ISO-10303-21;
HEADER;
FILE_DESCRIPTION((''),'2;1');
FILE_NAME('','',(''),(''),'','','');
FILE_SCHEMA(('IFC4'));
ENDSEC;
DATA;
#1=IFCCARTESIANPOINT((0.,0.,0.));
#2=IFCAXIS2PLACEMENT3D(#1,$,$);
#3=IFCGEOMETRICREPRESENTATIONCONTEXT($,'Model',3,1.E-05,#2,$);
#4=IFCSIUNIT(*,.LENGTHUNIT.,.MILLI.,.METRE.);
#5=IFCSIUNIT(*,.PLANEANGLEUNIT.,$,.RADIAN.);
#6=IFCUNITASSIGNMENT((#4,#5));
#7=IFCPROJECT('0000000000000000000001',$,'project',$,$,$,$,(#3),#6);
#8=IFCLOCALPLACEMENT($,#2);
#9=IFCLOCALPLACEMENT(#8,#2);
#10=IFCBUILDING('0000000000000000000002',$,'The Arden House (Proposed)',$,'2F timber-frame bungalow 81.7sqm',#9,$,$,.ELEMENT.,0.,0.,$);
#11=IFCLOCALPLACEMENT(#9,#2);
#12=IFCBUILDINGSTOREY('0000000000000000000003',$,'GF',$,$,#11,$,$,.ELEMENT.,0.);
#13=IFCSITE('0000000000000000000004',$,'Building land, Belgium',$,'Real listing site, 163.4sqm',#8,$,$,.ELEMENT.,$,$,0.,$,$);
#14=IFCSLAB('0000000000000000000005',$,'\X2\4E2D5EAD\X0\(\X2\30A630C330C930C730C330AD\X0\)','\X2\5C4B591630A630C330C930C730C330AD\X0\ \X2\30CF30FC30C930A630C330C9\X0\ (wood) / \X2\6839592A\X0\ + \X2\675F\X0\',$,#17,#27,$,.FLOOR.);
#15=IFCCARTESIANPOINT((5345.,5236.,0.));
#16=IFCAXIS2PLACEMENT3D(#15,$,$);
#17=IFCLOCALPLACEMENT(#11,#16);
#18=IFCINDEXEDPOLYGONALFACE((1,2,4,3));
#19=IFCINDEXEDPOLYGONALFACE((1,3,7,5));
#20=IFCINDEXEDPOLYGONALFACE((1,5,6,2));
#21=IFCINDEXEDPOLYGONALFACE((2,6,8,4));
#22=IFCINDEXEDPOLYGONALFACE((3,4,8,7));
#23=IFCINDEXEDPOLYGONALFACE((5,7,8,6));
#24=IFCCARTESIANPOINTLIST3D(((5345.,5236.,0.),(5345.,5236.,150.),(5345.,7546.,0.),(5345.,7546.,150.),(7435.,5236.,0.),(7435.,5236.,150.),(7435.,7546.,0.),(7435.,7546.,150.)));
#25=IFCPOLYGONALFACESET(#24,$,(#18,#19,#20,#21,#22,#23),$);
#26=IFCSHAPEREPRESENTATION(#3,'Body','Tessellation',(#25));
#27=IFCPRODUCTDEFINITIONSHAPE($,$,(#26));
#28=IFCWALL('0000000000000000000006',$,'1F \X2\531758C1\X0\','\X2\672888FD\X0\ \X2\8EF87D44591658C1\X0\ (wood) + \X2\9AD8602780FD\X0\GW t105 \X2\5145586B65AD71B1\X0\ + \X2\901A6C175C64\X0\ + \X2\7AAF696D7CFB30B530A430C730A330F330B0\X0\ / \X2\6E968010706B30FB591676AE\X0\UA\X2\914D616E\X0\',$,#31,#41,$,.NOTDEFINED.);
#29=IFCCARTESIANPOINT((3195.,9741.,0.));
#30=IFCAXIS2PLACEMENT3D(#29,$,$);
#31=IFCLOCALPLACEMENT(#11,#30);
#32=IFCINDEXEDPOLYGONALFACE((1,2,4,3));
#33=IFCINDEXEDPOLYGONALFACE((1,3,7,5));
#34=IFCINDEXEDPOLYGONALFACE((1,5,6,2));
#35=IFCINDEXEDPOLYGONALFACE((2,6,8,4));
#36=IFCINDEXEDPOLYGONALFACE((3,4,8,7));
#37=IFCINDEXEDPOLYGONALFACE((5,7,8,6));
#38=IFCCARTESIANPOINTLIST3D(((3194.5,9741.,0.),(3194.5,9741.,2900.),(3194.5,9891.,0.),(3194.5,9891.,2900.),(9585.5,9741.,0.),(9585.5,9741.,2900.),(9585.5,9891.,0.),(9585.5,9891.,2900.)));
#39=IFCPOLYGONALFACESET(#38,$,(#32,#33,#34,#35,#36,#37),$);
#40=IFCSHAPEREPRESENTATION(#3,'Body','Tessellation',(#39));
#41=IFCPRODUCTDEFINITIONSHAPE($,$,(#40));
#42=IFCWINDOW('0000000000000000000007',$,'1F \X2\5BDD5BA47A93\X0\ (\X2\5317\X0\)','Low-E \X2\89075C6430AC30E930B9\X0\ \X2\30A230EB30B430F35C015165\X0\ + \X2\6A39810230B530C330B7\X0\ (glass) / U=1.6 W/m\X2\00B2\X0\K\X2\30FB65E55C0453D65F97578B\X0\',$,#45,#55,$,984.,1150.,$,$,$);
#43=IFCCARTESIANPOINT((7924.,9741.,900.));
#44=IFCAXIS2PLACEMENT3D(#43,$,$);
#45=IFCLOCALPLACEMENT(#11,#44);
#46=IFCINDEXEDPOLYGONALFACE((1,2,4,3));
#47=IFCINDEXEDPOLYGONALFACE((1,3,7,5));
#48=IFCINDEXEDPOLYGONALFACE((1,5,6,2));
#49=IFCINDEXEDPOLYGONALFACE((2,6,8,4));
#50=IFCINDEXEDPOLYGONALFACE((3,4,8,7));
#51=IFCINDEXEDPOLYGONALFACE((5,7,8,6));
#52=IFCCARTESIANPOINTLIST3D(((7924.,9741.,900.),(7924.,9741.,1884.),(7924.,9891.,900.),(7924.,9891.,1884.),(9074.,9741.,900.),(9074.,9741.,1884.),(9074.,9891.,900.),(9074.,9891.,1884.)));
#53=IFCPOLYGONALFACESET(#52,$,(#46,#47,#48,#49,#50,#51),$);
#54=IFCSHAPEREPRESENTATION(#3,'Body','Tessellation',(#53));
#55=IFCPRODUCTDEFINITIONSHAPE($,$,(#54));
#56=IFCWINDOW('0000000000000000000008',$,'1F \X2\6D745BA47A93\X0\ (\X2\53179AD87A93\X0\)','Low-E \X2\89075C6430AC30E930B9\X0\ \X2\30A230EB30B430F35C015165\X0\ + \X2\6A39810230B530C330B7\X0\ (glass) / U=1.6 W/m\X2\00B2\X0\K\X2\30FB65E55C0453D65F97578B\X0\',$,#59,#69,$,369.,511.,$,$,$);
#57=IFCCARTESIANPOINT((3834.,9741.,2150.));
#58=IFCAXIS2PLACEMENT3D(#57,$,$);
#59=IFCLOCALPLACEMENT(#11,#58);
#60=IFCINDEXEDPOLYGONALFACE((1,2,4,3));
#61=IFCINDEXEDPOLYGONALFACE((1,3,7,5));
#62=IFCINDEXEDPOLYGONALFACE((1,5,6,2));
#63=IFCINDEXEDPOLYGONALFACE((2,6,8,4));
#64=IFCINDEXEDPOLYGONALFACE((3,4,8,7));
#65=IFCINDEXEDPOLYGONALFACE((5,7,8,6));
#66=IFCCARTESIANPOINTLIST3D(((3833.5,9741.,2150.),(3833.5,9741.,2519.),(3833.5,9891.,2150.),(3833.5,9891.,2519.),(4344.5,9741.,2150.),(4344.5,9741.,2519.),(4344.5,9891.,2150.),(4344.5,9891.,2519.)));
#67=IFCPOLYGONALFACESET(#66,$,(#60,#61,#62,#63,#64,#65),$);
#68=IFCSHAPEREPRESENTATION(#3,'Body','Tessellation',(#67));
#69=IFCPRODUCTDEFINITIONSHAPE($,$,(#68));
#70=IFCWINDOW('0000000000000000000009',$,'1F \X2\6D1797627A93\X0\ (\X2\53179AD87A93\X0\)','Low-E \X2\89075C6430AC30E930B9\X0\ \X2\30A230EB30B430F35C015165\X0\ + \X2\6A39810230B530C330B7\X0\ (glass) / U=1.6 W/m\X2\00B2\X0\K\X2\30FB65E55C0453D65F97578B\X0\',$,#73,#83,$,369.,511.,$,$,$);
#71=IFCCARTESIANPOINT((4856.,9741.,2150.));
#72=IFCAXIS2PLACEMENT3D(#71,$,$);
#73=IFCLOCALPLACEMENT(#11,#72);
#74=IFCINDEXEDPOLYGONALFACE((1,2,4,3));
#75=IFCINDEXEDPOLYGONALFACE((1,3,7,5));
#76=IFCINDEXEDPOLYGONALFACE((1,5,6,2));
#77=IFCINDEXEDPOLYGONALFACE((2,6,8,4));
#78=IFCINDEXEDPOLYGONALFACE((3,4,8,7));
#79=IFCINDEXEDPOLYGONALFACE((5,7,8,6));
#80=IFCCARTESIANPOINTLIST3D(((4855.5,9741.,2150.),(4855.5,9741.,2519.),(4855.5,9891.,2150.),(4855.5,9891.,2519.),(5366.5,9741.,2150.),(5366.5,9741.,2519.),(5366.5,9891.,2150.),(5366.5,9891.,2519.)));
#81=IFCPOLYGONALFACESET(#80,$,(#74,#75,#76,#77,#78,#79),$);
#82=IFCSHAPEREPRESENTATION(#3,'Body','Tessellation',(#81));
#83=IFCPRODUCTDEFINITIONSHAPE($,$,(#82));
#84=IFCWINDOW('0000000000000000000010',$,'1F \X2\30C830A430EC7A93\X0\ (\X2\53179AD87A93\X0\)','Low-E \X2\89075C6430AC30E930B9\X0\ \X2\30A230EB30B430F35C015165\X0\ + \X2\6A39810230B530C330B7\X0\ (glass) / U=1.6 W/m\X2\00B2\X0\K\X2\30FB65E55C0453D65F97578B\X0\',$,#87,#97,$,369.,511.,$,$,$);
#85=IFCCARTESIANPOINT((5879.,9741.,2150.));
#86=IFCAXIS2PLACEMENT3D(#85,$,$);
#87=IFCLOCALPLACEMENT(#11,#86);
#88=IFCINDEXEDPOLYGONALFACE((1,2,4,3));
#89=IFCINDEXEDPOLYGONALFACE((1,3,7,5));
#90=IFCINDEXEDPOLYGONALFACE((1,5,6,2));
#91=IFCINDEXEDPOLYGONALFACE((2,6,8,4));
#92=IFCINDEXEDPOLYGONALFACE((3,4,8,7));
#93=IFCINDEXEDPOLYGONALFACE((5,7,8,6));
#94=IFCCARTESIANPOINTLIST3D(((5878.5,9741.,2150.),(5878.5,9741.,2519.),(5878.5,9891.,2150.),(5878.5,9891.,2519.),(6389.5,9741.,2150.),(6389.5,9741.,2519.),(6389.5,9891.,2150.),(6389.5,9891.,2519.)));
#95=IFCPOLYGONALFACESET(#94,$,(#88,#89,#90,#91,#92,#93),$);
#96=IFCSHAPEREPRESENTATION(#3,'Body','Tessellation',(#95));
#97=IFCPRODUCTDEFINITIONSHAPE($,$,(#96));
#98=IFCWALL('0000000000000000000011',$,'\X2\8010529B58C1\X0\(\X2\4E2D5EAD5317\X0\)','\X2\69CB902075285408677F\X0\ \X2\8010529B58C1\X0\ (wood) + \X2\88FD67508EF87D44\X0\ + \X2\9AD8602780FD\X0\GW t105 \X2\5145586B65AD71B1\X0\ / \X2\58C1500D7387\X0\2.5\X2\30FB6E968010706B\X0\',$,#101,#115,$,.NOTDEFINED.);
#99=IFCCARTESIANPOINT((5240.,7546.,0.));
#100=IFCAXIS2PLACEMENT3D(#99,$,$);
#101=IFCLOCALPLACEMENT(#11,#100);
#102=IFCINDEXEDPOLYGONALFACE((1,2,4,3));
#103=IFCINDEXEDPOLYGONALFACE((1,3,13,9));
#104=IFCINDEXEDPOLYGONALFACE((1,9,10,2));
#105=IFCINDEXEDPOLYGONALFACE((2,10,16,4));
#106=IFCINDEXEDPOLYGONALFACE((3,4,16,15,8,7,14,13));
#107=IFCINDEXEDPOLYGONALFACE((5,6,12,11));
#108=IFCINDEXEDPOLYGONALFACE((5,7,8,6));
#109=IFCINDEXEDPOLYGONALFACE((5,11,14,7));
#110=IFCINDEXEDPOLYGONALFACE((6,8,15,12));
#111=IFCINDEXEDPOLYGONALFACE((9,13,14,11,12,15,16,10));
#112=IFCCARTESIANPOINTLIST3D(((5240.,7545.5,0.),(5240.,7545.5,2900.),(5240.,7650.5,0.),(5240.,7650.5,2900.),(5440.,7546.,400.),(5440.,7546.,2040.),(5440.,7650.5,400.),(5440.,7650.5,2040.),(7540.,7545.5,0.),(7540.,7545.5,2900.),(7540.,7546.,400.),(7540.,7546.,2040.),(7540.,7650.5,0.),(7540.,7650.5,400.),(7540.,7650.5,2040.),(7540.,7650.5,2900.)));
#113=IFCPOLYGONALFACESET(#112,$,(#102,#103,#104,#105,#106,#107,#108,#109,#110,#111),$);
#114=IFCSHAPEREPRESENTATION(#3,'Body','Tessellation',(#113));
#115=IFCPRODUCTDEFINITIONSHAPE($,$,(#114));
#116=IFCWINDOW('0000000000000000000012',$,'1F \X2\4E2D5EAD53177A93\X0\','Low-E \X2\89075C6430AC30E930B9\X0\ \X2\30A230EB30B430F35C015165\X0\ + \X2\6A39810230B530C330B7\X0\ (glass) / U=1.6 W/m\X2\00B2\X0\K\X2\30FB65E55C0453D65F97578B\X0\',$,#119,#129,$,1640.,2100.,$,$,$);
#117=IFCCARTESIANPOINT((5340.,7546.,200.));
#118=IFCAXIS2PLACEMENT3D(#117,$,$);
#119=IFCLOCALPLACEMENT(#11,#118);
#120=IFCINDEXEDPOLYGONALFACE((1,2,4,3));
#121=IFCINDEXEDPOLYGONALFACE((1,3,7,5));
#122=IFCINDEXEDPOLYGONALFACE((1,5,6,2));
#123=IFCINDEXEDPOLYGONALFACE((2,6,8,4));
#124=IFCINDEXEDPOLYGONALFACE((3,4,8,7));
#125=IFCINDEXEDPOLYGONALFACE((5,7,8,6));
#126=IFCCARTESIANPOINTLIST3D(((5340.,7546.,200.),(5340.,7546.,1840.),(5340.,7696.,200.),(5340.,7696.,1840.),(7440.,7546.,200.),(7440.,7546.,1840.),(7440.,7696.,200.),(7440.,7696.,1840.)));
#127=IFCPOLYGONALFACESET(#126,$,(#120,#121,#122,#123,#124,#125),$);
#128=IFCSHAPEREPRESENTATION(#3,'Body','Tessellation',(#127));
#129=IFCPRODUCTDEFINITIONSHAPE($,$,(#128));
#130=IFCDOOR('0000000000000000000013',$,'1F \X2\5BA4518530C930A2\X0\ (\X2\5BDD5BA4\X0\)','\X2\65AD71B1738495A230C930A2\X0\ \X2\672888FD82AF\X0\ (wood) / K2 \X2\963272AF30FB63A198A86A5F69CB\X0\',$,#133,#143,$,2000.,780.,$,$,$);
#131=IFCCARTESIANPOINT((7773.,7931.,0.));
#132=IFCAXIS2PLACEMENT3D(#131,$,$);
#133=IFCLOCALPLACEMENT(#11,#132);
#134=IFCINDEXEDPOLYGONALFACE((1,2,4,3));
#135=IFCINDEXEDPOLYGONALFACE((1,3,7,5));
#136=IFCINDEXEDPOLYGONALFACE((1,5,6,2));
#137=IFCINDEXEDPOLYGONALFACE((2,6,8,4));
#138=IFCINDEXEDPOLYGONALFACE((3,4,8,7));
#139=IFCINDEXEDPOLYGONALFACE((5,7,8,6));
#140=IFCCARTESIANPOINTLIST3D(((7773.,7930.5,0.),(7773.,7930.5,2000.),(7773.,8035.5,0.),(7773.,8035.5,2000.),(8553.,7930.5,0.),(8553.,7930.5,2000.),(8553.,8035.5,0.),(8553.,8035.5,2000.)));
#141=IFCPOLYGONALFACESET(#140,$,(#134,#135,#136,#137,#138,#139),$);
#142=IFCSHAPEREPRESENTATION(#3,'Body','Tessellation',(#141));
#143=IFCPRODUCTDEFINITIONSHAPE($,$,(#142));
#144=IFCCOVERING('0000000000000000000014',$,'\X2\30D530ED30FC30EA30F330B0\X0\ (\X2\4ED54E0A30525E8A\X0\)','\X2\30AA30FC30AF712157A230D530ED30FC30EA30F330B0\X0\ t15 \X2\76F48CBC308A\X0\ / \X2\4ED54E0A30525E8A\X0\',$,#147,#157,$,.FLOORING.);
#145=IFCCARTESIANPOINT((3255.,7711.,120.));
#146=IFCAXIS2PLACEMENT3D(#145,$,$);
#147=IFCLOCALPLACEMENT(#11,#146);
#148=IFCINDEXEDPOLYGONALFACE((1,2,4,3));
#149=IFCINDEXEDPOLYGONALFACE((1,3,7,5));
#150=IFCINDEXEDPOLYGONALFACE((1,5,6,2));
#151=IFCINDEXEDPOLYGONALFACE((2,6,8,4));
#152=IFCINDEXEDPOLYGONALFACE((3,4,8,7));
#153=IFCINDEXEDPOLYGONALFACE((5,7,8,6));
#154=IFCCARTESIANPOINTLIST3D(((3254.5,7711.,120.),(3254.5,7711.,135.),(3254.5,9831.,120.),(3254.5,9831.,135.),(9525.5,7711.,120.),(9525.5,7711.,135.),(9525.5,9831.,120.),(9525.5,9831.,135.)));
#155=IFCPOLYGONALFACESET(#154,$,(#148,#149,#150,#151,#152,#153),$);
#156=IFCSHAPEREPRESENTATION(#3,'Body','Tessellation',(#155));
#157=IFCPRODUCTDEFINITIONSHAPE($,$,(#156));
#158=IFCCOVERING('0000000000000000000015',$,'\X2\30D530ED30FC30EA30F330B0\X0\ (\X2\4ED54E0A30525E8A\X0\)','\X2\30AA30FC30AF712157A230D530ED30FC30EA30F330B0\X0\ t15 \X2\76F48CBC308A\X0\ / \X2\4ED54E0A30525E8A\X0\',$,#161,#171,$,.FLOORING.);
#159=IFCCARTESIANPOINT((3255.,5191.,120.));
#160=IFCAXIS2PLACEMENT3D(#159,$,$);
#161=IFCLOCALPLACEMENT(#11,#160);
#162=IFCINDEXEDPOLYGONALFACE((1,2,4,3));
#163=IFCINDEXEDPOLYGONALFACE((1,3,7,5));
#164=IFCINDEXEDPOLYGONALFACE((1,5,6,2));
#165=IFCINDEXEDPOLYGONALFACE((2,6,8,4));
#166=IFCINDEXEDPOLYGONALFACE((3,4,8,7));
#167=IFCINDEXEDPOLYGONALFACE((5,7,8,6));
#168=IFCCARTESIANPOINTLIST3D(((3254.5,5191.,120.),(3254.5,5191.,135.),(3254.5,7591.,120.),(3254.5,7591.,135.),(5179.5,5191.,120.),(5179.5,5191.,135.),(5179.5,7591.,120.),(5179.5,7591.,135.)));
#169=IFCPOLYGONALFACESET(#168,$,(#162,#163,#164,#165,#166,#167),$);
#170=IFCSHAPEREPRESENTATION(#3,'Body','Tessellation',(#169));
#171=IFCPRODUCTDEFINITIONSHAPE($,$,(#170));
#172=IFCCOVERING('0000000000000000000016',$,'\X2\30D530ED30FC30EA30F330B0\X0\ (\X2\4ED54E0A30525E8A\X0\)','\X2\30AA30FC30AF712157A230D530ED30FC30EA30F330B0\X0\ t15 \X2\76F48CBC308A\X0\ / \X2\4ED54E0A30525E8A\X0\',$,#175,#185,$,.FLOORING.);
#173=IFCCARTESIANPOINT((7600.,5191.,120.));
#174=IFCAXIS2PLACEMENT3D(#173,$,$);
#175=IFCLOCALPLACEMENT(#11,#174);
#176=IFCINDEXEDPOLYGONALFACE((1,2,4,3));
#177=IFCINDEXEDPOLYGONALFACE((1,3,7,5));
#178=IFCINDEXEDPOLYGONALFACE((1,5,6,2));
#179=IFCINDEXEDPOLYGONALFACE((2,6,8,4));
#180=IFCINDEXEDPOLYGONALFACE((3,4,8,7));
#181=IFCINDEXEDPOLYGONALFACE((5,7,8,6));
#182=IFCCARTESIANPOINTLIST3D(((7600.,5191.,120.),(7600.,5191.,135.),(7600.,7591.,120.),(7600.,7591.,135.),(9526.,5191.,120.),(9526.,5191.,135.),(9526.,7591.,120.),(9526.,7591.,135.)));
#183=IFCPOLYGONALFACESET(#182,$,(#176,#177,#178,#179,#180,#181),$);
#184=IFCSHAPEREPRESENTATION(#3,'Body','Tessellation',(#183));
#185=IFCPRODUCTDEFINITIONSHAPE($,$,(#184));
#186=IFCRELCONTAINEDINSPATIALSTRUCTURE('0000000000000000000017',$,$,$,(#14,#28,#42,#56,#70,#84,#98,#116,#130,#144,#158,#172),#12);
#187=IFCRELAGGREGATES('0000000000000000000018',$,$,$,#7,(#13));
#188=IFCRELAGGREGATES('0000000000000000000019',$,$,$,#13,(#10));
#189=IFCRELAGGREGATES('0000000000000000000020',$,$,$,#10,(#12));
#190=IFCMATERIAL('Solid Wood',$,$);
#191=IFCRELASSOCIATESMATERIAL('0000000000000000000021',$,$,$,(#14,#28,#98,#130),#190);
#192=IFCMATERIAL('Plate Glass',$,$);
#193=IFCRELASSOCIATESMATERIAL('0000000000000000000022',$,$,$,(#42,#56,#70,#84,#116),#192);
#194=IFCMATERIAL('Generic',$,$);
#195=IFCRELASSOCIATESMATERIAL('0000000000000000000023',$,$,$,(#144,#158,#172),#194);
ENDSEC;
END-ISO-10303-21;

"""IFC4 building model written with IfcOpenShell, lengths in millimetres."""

from ifc_helpers import new_model, si_unit, frame, frame_2d, origin, place, context, project, spatial, rectangle, extrude, material, element, fill, save


model = new_model("IFC4")

# Units and contexts
model_context = context("Model", 3, precision=1e-05, world=origin())
ifc_project = project(units=[si_unit("LENGTHUNIT", "METRE", prefix="MILLI"), si_unit("PLANEANGLEUNIT", "RADIAN")], contexts=[model_context])

# Site, building, storey
site_placement = place(None, origin())
site = spatial("IfcSite", under=ifc_project, at=site_placement, Name="Building land, Belgium", ObjectType="Real listing site, 163.4sqm", CompositionType="ELEMENT", RefElevation=0.0)
building_placement = place(site_placement, origin())
building = spatial("IfcBuilding", under=site, at=building_placement, Name="The Arden House (Proposed)", ObjectType="2F timber-frame bungalow 81.7sqm", CompositionType="ELEMENT", ElevationOfRefHeight=0.0, ElevationOfTerrain=0.0)
storey_placement = place(building_placement, origin())
storey = spatial("IfcBuildingStorey", under=building, at=storey_placement, Name="GF", CompositionType="ELEMENT", Elevation=0.0)

# Slab
ifc_material_1 = material(Name="Solid Wood")
slab_1_placement = place(storey_placement, frame((5345.0, 5236.0, 0.0)))
element("IfcSlab", 1, at=slab_1_placement, inside=storey, material=ifc_material_1, Name="中庭(ウッドデッキ)", Description="屋外ウッドデッキ ハードウッド (wood) / 根太 + 束", PredefinedType="FLOOR", context=model_context, shape_type="SweptSolid", body=[
    extrude(rectangle(XDim=2090.0, YDim=2310.0, at=frame_2d((1045.0, 1155.0))), frame((5345.0, 5236.0, 0.0)), (0.0, 0.0, 1.0), 150.0),
])

# Wall, openings, windows
wall_1_placement = place(storey_placement, frame((3195.0, 9741.0, 0.0)))
wall_1 = element("IfcWall", 2, at=wall_1_placement, inside=storey, material=ifc_material_1, Name="1F 北壁", Description="木製 軸組外壁 (wood) + 高性能GW t105 充填断熱 + 通気層 + 窯業系サイディング / 準耐火・外皮UA配慮", PredefinedType="NOTDEFINED", context=model_context, shape_type="SweptSolid", body=[
    extrude(rectangle(XDim=6391.0, YDim=150.0, at=frame_2d((3195.0, 75.0))), frame((3195.0, 9741.0, 0.0)), (0.0, 0.0, 1.0), 2900.0),
])
opening_1_placement = place(storey_placement, frame((7924.0, 9741.0, 900.0)))
opening_1 = element("IfcOpeningElement", 3, at=opening_1_placement, cuts=wall_1, PredefinedType="NOTDEFINED", context=model_context, shape_type="SweptSolid", body=[
    extrude(rectangle(XDim=1150.0, YDim=150.0, at=frame_2d((575.0, 75.0))), frame((7924.0, 9741.0, 900.0)), (0.0, 0.0, 1.0), 984.0),
])
opening_2_placement = place(storey_placement, frame((3834.0, 9741.0, 2150.0)))
opening_2 = element("IfcOpeningElement", 4, at=opening_2_placement, cuts=wall_1, PredefinedType="NOTDEFINED", context=model_context, shape_type="SweptSolid", body=[
    extrude(rectangle(XDim=511.0, YDim=150.0, at=frame_2d((255.0, 75.0))), frame((3834.0, 9741.0, 2150.0)), (0.0, 0.0, 1.0), 369.0),
])
opening_3_placement = place(storey_placement, frame((4856.0, 9741.0, 2150.0)))
opening_3 = element("IfcOpeningElement", 5, at=opening_3_placement, cuts=wall_1, PredefinedType="NOTDEFINED", context=model_context, shape_type="SweptSolid", body=[
    extrude(rectangle(XDim=511.0, YDim=150.0, at=frame_2d((255.0, 75.0))), frame((4856.0, 9741.0, 2150.0)), (0.0, 0.0, 1.0), 369.0),
])
opening_4_placement = place(storey_placement, frame((5879.0, 9741.0, 2150.0)))
opening_4 = element("IfcOpeningElement", 6, at=opening_4_placement, cuts=wall_1, PredefinedType="NOTDEFINED", context=model_context, shape_type="SweptSolid", body=[
    extrude(rectangle(XDim=511.0, YDim=150.0, at=frame_2d((255.0, 75.0))), frame((5879.0, 9741.0, 2150.0)), (0.0, 0.0, 1.0), 369.0),
])
ifc_material_2 = material(Name="Plate Glass")
window_1_placement = place(storey_placement, frame((7924.0, 9741.0, 900.0)))
window_1 = element("IfcWindow", 7, at=window_1_placement, inside=storey, material=ifc_material_2, Name="1F 寝室窓 (北)", Description="Low-E 複層ガラス アルゴン封入 + 樹脂サッシ (glass) / U=1.6 W/m²K・日射取得型", OverallHeight=984.0, OverallWidth=1150.0, context=model_context, shape_type="SweptSolid", body=[
    extrude(rectangle(XDim=1150.0, YDim=150.0, at=frame_2d((575.0, 75.0))), frame((7924.0, 9741.0, 900.0)), (0.0, 0.0, 1.0), 984.0),
])
fill(opening_1, window_1)
window_2_placement = place(storey_placement, frame((3834.0, 9741.0, 2150.0)))
window_2 = element("IfcWindow", 8, at=window_2_placement, inside=storey, material=ifc_material_2, Name="1F 浴室窓 (北高窓)", Description="Low-E 複層ガラス アルゴン封入 + 樹脂サッシ (glass) / U=1.6 W/m²K・日射取得型", OverallHeight=369.0, OverallWidth=511.0, context=model_context, shape_type="SweptSolid", body=[
    extrude(rectangle(XDim=511.0, YDim=150.0, at=frame_2d((255.0, 75.0))), frame((3834.0, 9741.0, 2150.0)), (0.0, 0.0, 1.0), 369.0),
])
fill(opening_2, window_2)
window_3_placement = place(storey_placement, frame((4856.0, 9741.0, 2150.0)))
window_3 = element("IfcWindow", 9, at=window_3_placement, inside=storey, material=ifc_material_2, Name="1F 洗面窓 (北高窓)", Description="Low-E 複層ガラス アルゴン封入 + 樹脂サッシ (glass) / U=1.6 W/m²K・日射取得型", OverallHeight=369.0, OverallWidth=511.0, context=model_context, shape_type="SweptSolid", body=[
    extrude(rectangle(XDim=511.0, YDim=150.0, at=frame_2d((255.0, 75.0))), frame((4856.0, 9741.0, 2150.0)), (0.0, 0.0, 1.0), 369.0),
])
fill(opening_3, window_3)
window_4_placement = place(storey_placement, frame((5879.0, 9741.0, 2150.0)))
window_4 = element("IfcWindow", 10, at=window_4_placement, inside=storey, material=ifc_material_2, Name="1F トイレ窓 (北高窓)", Description="Low-E 複層ガラス アルゴン封入 + 樹脂サッシ (glass) / U=1.6 W/m²K・日射取得型", OverallHeight=369.0, OverallWidth=511.0, context=model_context, shape_type="SweptSolid", body=[
    extrude(rectangle(XDim=511.0, YDim=150.0, at=frame_2d((255.0, 75.0))), frame((5879.0, 9741.0, 2150.0)), (0.0, 0.0, 1.0), 369.0),
])
fill(opening_4, window_4)

# Wall, opening, window
wall_2_placement = place(storey_placement, frame((5240.0, 7546.0, 0.0)))
wall_2 = element("IfcWall", 11, at=wall_2_placement, inside=storey, material=ifc_material_1, Name="耐力壁(中庭北)", Description="構造用合板 耐力壁 (wood) + 製材軸組 + 高性能GW t105 充填断熱 / 壁倍率2.5・準耐火", PredefinedType="NOTDEFINED", context=model_context, shape_type="SweptSolid", body=[
    extrude(rectangle(XDim=2300.0, YDim=105.0, at=frame_2d((1150.0, 52.0))), frame((5240.0, 7546.0, 0.0)), (0.0, 0.0, 1.0), 2900.0),
])
opening_5_placement = place(storey_placement, frame((5340.0, 7546.0, 200.0)))
opening_5 = element("IfcOpeningElement", 12, at=opening_5_placement, cuts=wall_2, PredefinedType="NOTDEFINED", context=model_context, shape_type="SweptSolid", body=[
    extrude(rectangle(XDim=2100.0, YDim=150.0, at=frame_2d((1050.0, 75.0))), frame((5340.0, 7546.0, 200.0)), (0.0, 0.0, 1.0), 1640.0),
])
window_5_placement = place(storey_placement, frame((5340.0, 7546.0, 200.0)))
window_5 = element("IfcWindow", 13, at=window_5_placement, inside=storey, material=ifc_material_2, Name="1F 中庭北窓", Description="Low-E 複層ガラス アルゴン封入 + 樹脂サッシ (glass) / U=1.6 W/m²K・日射取得型", OverallHeight=1640.0, OverallWidth=2100.0, context=model_context, shape_type="SweptSolid", body=[
    extrude(rectangle(XDim=2100.0, YDim=150.0, at=frame_2d((1050.0, 75.0))), frame((5340.0, 7546.0, 200.0)), (0.0, 0.0, 1.0), 1640.0),
])
fill(opening_5, window_5)

# Door
door_1_placement = place(storey_placement, frame((7773.0, 7931.0, 0.0)))
element("IfcDoor", 14, at=door_1_placement, inside=storey, material=ifc_material_1, Name="1F 室内ドア (寝室)", Description="断熱玄関ドア 木製芯 (wood) / K2 防犯・採風機構", OverallHeight=2000.0, OverallWidth=780.0, context=model_context, shape_type="SweptSolid", body=[
    extrude(rectangle(XDim=780.0, YDim=105.0, at=frame_2d((390.0, 52.0))), frame((7773.0, 7931.0, 0.0)), (0.0, 0.0, 1.0), 2000.0),
])

# Coverings
ifc_material_3 = material(Name="Generic")
covering_1_placement = place(storey_placement, frame((3255.0, 7711.0, 120.0)))
element("IfcCovering", 15, at=covering_1_placement, inside=storey, material=ifc_material_3, Name="フローリング (仕上げ床)", Description="オーク無垢フローリング t15 直貼り / 仕上げ床", PredefinedType="FLOORING", context=model_context, shape_type="SweptSolid", body=[
    extrude(rectangle(XDim=6271.0, YDim=2120.0, at=frame_2d((3135.0, 1060.0))), frame((3255.0, 7711.0, 120.0)), (0.0, 0.0, 1.0), 15.0),
])
covering_2_placement = place(storey_placement, frame((3255.0, 5191.0, 120.0)))
element("IfcCovering", 16, at=covering_2_placement, inside=storey, material=ifc_material_3, Name="フローリング (仕上げ床)", Description="オーク無垢フローリング t15 直貼り / 仕上げ床", PredefinedType="FLOORING", context=model_context, shape_type="SweptSolid", body=[
    extrude(rectangle(XDim=1925.0, YDim=2400.0, at=frame_2d((962.0, 1200.0))), frame((3255.0, 5191.0, 120.0)), (0.0, 0.0, 1.0), 15.0),
])
covering_3_placement = place(storey_placement, frame((7600.0, 5191.0, 120.0)))
element("IfcCovering", 17, at=covering_3_placement, inside=storey, material=ifc_material_3, Name="フローリング (仕上げ床)", Description="オーク無垢フローリング t15 直貼り / 仕上げ床", PredefinedType="FLOORING", context=model_context, shape_type="SweptSolid", body=[
    extrude(rectangle(XDim=1926.0, YDim=2400.0, at=frame_2d((963.0, 1200.0))), frame((7600.0, 5191.0, 120.0)), (0.0, 0.0, 1.0), 15.0),
])

save(model, "model.ifc")
